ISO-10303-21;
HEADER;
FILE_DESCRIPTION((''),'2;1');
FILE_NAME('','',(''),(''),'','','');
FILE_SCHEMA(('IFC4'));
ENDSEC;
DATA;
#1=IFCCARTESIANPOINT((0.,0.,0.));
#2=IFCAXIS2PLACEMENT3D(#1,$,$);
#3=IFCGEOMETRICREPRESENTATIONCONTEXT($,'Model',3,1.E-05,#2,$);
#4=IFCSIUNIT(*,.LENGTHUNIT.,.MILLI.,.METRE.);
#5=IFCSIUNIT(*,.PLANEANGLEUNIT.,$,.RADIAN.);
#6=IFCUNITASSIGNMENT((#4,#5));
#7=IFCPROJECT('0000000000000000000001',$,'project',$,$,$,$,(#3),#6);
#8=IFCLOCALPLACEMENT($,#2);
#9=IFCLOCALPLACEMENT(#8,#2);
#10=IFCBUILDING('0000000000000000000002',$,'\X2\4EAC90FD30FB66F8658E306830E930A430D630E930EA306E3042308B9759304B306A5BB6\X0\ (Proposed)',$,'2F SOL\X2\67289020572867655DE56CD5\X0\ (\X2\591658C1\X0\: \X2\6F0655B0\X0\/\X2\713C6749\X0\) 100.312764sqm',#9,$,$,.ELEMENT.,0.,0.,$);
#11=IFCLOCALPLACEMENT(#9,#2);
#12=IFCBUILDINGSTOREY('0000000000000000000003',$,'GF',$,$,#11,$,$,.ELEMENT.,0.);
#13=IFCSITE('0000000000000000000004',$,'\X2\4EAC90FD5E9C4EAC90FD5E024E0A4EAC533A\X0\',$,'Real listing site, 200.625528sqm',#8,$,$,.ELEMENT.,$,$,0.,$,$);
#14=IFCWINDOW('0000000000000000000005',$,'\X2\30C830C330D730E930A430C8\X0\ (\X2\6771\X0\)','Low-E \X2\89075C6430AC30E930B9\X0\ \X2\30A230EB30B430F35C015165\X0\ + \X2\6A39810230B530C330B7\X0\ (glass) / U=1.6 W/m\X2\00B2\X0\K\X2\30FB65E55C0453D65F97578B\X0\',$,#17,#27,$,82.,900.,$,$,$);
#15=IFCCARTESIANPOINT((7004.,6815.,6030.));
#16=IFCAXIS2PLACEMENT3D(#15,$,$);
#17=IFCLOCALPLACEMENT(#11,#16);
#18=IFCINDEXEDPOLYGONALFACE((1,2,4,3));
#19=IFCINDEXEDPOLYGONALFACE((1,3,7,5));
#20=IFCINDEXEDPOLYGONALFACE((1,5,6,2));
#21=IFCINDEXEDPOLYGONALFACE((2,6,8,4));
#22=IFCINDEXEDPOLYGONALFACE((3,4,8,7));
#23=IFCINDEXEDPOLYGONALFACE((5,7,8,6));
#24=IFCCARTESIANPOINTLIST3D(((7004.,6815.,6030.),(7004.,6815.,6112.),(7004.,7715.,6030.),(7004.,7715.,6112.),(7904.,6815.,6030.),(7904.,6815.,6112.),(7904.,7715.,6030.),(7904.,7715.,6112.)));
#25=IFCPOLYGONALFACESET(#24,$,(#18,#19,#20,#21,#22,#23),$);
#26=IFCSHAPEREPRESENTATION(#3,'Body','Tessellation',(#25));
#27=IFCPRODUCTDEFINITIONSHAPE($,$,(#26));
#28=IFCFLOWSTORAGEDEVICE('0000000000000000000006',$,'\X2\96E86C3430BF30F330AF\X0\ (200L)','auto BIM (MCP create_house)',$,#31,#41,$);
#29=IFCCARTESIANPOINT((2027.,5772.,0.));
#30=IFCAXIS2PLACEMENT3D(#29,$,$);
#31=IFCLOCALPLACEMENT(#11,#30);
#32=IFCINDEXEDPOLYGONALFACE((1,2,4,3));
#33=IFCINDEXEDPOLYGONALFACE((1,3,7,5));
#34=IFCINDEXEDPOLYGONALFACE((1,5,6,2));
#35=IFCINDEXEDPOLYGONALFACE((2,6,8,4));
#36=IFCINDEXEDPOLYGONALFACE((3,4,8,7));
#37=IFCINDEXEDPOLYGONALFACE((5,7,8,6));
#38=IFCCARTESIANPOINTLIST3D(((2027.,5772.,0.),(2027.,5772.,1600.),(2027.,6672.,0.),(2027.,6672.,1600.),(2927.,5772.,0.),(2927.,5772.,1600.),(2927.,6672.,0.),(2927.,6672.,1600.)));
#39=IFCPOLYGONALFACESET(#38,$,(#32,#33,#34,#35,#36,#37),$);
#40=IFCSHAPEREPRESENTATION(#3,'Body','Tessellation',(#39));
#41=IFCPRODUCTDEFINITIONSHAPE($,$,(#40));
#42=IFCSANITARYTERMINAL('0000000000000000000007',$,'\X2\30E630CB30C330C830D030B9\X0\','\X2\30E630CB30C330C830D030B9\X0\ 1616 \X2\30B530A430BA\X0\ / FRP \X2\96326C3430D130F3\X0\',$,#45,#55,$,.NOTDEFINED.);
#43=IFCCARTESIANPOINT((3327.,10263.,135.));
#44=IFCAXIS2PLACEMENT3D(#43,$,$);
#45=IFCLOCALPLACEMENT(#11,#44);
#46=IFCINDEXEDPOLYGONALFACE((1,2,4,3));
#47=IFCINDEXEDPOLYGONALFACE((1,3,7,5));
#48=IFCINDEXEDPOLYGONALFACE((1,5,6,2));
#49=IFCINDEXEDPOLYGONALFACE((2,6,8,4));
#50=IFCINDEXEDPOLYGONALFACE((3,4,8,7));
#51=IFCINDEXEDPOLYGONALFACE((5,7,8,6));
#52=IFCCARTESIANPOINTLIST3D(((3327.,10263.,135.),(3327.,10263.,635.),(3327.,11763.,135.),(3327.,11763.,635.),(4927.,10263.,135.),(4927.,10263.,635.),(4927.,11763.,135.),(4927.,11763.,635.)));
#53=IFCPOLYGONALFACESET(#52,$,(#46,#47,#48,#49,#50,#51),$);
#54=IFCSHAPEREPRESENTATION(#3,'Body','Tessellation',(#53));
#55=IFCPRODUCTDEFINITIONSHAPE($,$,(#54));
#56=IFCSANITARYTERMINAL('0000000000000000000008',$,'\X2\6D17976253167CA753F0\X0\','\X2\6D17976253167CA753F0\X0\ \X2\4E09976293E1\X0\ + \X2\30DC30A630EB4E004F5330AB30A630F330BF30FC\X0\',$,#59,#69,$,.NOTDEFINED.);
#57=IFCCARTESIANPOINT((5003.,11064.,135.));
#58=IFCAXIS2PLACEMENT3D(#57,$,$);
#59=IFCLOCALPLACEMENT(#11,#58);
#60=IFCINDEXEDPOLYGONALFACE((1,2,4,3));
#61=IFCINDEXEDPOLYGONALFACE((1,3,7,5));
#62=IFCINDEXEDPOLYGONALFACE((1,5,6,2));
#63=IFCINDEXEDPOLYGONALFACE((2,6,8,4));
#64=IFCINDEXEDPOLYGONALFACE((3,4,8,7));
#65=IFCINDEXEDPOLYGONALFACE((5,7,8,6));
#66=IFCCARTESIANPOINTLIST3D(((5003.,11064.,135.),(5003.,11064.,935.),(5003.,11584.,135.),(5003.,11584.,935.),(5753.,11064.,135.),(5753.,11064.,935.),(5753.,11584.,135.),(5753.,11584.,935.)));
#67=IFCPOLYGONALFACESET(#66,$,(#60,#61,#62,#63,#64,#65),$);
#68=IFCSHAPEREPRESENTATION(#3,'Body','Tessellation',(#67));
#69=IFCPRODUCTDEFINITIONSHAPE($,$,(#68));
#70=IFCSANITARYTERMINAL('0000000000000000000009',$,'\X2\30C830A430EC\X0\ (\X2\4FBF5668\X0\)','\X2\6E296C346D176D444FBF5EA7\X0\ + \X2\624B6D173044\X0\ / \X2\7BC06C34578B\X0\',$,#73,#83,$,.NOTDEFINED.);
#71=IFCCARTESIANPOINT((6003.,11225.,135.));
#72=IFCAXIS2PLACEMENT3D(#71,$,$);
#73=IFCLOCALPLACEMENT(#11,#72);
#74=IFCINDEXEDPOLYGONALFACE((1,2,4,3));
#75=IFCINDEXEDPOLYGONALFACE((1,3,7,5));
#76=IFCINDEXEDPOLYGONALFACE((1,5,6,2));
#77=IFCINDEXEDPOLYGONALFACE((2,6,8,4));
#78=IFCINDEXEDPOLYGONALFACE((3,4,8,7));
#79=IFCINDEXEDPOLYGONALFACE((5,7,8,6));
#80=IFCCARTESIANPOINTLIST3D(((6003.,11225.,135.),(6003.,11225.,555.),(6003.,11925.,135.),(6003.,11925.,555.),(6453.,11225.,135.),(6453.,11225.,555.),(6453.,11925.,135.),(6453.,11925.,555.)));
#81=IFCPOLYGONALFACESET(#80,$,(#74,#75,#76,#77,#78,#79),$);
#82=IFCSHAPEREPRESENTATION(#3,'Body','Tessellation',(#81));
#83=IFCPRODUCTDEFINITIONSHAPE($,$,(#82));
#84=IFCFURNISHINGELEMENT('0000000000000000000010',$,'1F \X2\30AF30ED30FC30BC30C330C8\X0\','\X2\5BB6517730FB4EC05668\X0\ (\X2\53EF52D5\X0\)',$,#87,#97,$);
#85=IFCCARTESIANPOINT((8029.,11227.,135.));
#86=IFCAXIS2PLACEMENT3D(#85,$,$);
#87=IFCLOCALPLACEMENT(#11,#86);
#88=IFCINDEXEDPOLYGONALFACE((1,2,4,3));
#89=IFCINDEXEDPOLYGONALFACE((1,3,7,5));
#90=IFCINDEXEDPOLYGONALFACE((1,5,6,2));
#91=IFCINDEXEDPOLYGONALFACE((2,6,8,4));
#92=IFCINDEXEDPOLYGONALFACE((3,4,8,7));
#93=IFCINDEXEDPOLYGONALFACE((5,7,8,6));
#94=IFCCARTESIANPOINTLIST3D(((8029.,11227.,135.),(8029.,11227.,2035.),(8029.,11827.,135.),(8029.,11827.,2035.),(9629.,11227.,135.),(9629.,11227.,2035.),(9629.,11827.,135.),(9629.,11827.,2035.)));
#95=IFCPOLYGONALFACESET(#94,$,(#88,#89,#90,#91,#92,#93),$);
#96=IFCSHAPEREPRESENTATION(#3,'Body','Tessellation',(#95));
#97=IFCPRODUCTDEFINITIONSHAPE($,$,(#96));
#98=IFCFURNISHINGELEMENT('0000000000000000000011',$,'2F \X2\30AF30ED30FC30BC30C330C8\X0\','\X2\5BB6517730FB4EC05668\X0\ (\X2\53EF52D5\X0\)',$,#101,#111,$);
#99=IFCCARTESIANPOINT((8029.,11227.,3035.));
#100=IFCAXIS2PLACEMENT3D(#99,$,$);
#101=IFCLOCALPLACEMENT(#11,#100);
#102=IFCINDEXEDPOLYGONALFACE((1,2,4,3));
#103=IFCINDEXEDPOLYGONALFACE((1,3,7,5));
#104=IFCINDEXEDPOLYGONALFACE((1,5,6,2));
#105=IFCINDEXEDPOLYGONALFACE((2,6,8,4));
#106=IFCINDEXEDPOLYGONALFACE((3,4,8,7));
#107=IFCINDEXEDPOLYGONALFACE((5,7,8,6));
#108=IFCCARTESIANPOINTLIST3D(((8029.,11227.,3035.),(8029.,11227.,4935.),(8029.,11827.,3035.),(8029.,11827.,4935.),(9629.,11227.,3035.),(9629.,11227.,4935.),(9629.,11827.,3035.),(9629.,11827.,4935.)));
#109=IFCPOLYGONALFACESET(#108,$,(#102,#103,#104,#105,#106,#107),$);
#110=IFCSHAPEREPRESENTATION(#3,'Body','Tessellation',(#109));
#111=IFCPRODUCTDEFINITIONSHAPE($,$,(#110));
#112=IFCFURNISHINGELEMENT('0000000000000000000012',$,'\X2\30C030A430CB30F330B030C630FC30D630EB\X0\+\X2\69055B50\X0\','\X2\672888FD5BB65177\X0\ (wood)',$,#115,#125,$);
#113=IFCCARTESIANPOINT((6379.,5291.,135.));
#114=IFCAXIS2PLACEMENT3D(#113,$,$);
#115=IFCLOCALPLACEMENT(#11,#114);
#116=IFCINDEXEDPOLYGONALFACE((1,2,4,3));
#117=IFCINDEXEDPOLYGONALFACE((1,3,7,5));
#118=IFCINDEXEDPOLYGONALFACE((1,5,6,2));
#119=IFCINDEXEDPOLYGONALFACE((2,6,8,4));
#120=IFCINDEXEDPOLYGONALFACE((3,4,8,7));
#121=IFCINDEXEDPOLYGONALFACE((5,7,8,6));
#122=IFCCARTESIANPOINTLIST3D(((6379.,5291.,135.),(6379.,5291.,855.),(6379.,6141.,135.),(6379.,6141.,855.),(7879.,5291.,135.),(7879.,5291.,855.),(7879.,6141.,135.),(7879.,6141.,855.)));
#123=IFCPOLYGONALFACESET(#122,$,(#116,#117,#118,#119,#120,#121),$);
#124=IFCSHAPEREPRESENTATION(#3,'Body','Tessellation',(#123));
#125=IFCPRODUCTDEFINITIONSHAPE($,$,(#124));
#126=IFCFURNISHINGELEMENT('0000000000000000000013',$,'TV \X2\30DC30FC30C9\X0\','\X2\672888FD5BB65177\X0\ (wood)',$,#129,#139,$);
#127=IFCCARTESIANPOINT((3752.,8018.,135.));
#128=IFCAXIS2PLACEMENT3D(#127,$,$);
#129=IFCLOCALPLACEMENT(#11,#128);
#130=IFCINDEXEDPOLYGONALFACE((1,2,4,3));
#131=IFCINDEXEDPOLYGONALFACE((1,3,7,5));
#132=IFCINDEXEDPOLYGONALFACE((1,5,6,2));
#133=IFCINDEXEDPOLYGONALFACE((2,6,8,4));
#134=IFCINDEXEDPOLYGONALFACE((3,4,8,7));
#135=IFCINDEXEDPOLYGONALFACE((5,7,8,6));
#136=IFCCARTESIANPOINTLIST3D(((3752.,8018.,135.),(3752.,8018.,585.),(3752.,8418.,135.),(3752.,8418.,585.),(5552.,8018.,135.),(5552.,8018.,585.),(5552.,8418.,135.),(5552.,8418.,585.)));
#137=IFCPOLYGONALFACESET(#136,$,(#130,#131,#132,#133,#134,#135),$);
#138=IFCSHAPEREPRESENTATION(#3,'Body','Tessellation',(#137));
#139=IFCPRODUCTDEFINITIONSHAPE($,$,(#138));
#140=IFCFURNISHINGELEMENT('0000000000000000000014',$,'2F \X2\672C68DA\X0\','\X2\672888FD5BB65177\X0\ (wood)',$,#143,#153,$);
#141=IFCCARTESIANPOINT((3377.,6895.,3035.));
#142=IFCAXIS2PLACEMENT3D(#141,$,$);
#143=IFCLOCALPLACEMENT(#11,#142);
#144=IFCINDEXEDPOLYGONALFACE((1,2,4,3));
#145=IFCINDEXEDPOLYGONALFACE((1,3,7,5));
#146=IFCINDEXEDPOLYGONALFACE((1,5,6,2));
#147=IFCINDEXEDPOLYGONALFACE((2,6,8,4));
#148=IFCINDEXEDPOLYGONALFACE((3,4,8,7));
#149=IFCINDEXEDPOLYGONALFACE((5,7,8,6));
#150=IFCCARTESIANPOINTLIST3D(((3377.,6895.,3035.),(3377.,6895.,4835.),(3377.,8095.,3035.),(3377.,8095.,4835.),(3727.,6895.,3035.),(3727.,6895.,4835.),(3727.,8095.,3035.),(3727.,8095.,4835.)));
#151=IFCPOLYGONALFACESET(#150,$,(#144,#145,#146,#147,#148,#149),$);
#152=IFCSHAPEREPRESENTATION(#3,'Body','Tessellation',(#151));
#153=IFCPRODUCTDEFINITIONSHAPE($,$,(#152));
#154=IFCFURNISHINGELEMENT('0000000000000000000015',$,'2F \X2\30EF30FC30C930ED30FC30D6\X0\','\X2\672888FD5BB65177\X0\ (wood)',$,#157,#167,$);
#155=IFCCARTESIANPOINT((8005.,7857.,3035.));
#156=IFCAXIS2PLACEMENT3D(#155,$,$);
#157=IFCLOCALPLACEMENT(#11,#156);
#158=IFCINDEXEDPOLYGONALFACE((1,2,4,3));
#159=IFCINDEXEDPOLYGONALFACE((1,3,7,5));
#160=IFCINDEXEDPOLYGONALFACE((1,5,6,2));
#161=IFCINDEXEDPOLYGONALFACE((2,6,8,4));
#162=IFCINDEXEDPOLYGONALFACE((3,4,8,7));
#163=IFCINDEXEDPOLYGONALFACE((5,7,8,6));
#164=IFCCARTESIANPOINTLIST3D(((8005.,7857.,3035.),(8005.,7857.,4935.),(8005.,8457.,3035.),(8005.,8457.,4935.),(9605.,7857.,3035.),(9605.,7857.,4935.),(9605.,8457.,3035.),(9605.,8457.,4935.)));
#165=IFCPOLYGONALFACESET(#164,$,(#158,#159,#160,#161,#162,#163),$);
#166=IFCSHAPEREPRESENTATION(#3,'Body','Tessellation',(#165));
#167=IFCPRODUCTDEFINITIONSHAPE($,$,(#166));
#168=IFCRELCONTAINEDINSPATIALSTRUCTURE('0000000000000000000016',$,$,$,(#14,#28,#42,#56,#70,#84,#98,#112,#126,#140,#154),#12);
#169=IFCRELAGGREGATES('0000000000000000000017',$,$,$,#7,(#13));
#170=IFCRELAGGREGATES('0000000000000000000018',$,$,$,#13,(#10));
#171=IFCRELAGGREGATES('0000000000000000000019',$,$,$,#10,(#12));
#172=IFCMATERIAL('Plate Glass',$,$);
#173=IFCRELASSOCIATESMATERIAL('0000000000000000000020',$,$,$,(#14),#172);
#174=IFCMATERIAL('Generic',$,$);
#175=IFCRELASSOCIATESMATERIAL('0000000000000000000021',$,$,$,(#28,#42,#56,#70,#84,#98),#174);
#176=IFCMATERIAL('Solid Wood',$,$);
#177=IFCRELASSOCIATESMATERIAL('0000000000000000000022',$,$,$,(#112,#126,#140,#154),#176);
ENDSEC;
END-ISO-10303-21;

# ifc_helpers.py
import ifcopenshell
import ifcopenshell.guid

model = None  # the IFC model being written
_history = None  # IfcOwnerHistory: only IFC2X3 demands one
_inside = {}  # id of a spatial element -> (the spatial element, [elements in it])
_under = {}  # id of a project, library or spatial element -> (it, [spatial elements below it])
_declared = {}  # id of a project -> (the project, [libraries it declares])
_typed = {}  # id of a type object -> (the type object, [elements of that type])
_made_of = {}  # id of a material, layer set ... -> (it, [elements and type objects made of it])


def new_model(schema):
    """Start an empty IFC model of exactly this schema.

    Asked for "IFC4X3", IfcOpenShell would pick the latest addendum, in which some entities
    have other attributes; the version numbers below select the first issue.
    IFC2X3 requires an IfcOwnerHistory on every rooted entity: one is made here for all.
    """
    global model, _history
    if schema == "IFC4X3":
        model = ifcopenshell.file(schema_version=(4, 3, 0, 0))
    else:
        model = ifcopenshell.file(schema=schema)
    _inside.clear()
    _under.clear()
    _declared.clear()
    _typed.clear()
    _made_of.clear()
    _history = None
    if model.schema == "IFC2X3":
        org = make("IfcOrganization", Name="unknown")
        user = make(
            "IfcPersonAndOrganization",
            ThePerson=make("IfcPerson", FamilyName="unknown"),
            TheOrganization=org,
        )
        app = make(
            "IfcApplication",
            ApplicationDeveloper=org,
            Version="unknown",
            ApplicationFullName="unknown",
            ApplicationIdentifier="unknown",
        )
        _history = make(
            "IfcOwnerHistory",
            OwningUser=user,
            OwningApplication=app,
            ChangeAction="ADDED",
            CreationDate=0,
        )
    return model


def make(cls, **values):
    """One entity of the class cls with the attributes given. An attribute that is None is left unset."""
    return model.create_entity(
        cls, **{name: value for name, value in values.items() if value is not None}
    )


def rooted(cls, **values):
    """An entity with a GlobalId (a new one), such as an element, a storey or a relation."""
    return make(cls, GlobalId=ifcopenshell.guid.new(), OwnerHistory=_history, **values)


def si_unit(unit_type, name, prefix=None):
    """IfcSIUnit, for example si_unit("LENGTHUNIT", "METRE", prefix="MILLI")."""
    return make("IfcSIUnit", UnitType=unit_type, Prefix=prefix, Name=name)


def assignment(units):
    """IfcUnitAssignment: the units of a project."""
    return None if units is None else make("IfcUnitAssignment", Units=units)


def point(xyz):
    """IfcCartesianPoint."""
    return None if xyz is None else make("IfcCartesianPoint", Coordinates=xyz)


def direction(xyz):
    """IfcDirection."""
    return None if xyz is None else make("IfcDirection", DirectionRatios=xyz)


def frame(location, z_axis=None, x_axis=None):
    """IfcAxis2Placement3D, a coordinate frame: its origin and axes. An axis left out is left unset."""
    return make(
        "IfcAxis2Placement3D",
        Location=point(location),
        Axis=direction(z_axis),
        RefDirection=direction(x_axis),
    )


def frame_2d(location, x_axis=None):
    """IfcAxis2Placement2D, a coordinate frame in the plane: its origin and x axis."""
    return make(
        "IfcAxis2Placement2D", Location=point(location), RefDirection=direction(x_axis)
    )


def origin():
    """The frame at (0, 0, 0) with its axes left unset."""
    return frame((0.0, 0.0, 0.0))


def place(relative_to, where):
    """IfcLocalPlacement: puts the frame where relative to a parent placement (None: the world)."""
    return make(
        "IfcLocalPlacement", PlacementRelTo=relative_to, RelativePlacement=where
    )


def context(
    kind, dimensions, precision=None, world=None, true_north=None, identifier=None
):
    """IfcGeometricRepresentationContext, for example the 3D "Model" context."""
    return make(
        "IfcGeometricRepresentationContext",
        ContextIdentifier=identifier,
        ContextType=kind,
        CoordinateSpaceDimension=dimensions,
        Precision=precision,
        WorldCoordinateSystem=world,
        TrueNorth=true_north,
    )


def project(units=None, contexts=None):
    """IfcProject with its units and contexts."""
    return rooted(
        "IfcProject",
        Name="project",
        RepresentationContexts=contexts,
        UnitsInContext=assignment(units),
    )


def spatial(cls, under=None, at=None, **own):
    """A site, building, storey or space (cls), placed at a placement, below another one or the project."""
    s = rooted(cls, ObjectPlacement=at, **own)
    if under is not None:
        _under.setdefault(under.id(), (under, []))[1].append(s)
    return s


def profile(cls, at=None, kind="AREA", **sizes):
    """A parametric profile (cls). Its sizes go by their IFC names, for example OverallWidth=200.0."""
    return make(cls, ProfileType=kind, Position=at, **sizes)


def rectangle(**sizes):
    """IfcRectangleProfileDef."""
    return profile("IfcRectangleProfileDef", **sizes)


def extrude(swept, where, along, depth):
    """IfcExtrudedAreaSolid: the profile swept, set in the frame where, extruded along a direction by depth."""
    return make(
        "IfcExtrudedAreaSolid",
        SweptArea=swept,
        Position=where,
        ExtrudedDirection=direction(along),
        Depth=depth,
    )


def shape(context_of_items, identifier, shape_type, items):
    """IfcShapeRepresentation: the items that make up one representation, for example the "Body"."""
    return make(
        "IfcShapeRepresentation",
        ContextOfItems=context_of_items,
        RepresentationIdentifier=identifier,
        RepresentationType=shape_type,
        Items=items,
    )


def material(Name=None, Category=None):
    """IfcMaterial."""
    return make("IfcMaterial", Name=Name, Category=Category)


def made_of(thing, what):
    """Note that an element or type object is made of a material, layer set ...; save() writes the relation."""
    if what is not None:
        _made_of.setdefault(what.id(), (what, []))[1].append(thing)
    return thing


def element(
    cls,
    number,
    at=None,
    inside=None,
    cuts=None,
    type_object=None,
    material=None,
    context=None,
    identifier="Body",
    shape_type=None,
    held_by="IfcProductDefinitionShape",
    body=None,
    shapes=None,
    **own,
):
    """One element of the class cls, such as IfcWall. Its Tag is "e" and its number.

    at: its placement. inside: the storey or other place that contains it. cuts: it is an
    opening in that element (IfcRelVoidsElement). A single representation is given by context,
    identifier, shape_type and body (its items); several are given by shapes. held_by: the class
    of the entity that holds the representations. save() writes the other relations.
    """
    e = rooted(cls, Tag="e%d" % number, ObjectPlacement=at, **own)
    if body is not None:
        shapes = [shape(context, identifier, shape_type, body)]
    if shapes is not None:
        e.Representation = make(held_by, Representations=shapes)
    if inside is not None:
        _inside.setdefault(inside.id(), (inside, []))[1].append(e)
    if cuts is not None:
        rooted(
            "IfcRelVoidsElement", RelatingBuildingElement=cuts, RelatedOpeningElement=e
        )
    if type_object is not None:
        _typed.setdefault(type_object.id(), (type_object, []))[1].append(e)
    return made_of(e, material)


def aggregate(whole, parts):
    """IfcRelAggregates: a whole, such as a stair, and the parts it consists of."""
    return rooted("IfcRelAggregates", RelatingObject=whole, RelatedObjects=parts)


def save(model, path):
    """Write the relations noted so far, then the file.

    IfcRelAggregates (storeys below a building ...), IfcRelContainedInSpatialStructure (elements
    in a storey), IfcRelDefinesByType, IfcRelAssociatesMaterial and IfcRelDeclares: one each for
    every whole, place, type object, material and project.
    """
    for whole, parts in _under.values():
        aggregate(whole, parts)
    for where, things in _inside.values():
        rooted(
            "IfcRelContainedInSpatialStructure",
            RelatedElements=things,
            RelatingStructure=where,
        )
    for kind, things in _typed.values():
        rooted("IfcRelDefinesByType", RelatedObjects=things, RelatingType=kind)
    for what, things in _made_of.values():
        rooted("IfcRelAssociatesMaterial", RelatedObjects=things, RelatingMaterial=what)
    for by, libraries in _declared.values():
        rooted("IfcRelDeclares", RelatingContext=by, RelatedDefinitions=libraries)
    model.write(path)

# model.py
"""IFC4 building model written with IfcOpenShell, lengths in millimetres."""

from ifc_helpers import new_model, si_unit, frame, frame_2d, origin, place, context, project, spatial, rectangle, extrude, material, element, save


model = new_model("IFC4")

# Units and contexts
model_context = context("Model", 3, precision=1e-05, world=origin())
ifc_project = project(units=[si_unit("LENGTHUNIT", "METRE", prefix="MILLI"), si_unit("PLANEANGLEUNIT", "RADIAN")], contexts=[model_context])

# Site, building, storey
site_placement = place(None, origin())
site = spatial("IfcSite", under=ifc_project, at=site_placement, Name="京都府京都市上京区", ObjectType="Real listing site, 200.625528sqm", CompositionType="ELEMENT", RefElevation=0.0)
building_placement = place(site_placement, origin())
building = spatial("IfcBuilding", under=site, at=building_placement, Name="京都・書斎とライブラリのある静かな家 (Proposed)", ObjectType="2F SOL木造在来工法 (外壁: 漆喰/焼杉) 100.312764sqm", CompositionType="ELEMENT", ElevationOfRefHeight=0.0, ElevationOfTerrain=0.0)
storey_placement = place(building_placement, origin())
storey = spatial("IfcBuildingStorey", under=building, at=storey_placement, Name="GF", CompositionType="ELEMENT", Elevation=0.0)

# Shared definitions
ifc_material_1 = material(Name="Solid Wood")
ifc_material_2 = material(Name="Plate Glass")

# Window
window_1_placement = place(storey_placement, frame((7004.0, 6815.0, 6030.0)))
element("IfcWindow", 1, at=window_1_placement, inside=storey, material=ifc_material_2, Name="トップライト (東)", Description="Low-E 複層ガラス アルゴン封入 + 樹脂サッシ (glass) / U=1.6 W/m²K・日射取得型", OverallHeight=82.0, OverallWidth=900.0, context=model_context, shape_type="SweptSolid", body=[
    extrude(rectangle(XDim=900.0, YDim=900.0, at=frame_2d((450.0, 450.0))), frame((7004.0, 6815.0, 6030.0)), (0.0, 0.0, 1.0), 82.0),
])

# Flow storage device
ifc_material_3 = material(Name="Generic")
flow_storage_device_placement = place(storey_placement, frame((2027.0, 5772.0, 0.0)))
element("IfcFlowStorageDevice", 2, at=flow_storage_device_placement, inside=storey, material=ifc_material_3, Name="雨水タンク (200L)", Description="auto BIM (MCP create_house)", context=model_context, shape_type="SweptSolid", body=[
    extrude(rectangle(XDim=900.0, YDim=900.0, at=frame_2d((450.0, 450.0))), frame((2027.0, 5772.0, 0.0)), (0.0, 0.0, 1.0), 1600.0),
])

# Sanitary terminals
sanitary_terminal_1_placement = place(storey_placement, frame((3327.0, 10263.0, 135.0)))
element("IfcSanitaryTerminal", 3, at=sanitary_terminal_1_placement, inside=storey, material=ifc_material_3, Name="ユニットバス", Description="ユニットバス 1616 サイズ / FRP 防水パン", PredefinedType="NOTDEFINED", context=model_context, shape_type="SweptSolid", body=[
    extrude(rectangle(XDim=1600.0, YDim=1500.0, at=frame_2d((800.0, 750.0))), frame((3327.0, 10263.0, 135.0)), (0.0, 0.0, 1.0), 500.0),
])
sanitary_terminal_2_placement = place(storey_placement, frame((5003.0, 11064.0, 135.0)))
element("IfcSanitaryTerminal", 4, at=sanitary_terminal_2_placement, inside=storey, material=ifc_material_3, Name="洗面化粧台", Description="洗面化粧台 三面鏡 + ボウル一体カウンター", PredefinedType="NOTDEFINED", context=model_context, shape_type="SweptSolid", body=[
    extrude(rectangle(XDim=750.0, YDim=520.0, at=frame_2d((375.0, 260.0))), frame((5003.0, 11064.0, 135.0)), (0.0, 0.0, 1.0), 800.0),
])
sanitary_terminal_3_placement = place(storey_placement, frame((6003.0, 11225.0, 135.0)))
element("IfcSanitaryTerminal", 5, at=sanitary_terminal_3_placement, inside=storey, material=ifc_material_3, Name="トイレ (便器)", Description="温水洗浄便座 + 手洗い / 節水型", PredefinedType="NOTDEFINED", context=model_context, shape_type="SweptSolid", body=[
    extrude(rectangle(XDim=450.0, YDim=700.0, at=frame_2d((225.0, 350.0))), frame((6003.0, 11225.0, 135.0)), (0.0, 0.0, 1.0), 420.0),
])

# Furnishing elements
furnishing_1_placement = place(storey_placement, frame((8029.0, 11227.0, 135.0)))
element("IfcFurnishingElement", 6, at=furnishing_1_placement, inside=storey, material=ifc_material_3, Name="1F クローゼット", Description="家具・什器 (可動)", context=model_context, shape_type="SweptSolid", body=[
    extrude(rectangle(XDim=1600.0, YDim=600.0, at=frame_2d((800.0, 300.0))), frame((8029.0, 11227.0, 135.0)), (0.0, 0.0, 1.0), 1900.0),
])
furnishing_2_placement = place(storey_placement, frame((8029.0, 11227.0, 3035.0)))
element("IfcFurnishingElement", 7, at=furnishing_2_placement, inside=storey, material=ifc_material_3, Name="2F クローゼット", Description="家具・什器 (可動)", context=model_context, shape_type="SweptSolid", body=[
    extrude(rectangle(XDim=1600.0, YDim=600.0, at=frame_2d((800.0, 300.0))), frame((8029.0, 11227.0, 3035.0)), (0.0, 0.0, 1.0), 1900.0),
])
furnishing_3_placement = place(storey_placement, frame((6379.0, 5291.0, 135.0)))
element("IfcFurnishingElement", 8, at=furnishing_3_placement, inside=storey, material=ifc_material_1, Name="ダイニングテーブル+椅子", Description="木製家具 (wood)", context=model_context, shape_type="SweptSolid", body=[
    extrude(rectangle(XDim=1500.0, YDim=850.0, at=frame_2d((750.0, 425.0))), frame((6379.0, 5291.0, 135.0)), (0.0, 0.0, 1.0), 720.0),
])
furnishing_4_placement = place(storey_placement, frame((3752.0, 8018.0, 135.0)))
element("IfcFurnishingElement", 9, at=furnishing_4_placement, inside=storey, material=ifc_material_1, Name="TV ボード", Description="木製家具 (wood)", context=model_context, shape_type="SweptSolid", body=[
    extrude(rectangle(XDim=1800.0, YDim=400.0, at=frame_2d((900.0, 200.0))), frame((3752.0, 8018.0, 135.0)), (0.0, 0.0, 1.0), 450.0),
])
furnishing_5_placement = place(storey_placement, frame((3377.0, 6895.0, 3035.0)))
element("IfcFurnishingElement", 10, at=furnishing_5_placement, inside=storey, material=ifc_material_1, Name="2F 本棚", Description="木製家具 (wood)", context=model_context, shape_type="SweptSolid", body=[
    extrude(rectangle(XDim=350.0, YDim=1200.0, at=frame_2d((175.0, 600.0))), frame((3377.0, 6895.0, 3035.0)), (0.0, 0.0, 1.0), 1800.0),
])
furnishing_6_placement = place(storey_placement, frame((8005.0, 7857.0, 3035.0)))
element("IfcFurnishingElement", 11, at=furnishing_6_placement, inside=storey, material=ifc_material_1, Name="2F ワードローブ", Description="木製家具 (wood)", context=model_context, shape_type="SweptSolid", body=[
    extrude(rectangle(XDim=1600.0, YDim=600.0, at=frame_2d((800.0, 300.0))), frame((8005.0, 7857.0, 3035.0)), (0.0, 0.0, 1.0), 1900.0),
])

save(model, "model.ifc")
